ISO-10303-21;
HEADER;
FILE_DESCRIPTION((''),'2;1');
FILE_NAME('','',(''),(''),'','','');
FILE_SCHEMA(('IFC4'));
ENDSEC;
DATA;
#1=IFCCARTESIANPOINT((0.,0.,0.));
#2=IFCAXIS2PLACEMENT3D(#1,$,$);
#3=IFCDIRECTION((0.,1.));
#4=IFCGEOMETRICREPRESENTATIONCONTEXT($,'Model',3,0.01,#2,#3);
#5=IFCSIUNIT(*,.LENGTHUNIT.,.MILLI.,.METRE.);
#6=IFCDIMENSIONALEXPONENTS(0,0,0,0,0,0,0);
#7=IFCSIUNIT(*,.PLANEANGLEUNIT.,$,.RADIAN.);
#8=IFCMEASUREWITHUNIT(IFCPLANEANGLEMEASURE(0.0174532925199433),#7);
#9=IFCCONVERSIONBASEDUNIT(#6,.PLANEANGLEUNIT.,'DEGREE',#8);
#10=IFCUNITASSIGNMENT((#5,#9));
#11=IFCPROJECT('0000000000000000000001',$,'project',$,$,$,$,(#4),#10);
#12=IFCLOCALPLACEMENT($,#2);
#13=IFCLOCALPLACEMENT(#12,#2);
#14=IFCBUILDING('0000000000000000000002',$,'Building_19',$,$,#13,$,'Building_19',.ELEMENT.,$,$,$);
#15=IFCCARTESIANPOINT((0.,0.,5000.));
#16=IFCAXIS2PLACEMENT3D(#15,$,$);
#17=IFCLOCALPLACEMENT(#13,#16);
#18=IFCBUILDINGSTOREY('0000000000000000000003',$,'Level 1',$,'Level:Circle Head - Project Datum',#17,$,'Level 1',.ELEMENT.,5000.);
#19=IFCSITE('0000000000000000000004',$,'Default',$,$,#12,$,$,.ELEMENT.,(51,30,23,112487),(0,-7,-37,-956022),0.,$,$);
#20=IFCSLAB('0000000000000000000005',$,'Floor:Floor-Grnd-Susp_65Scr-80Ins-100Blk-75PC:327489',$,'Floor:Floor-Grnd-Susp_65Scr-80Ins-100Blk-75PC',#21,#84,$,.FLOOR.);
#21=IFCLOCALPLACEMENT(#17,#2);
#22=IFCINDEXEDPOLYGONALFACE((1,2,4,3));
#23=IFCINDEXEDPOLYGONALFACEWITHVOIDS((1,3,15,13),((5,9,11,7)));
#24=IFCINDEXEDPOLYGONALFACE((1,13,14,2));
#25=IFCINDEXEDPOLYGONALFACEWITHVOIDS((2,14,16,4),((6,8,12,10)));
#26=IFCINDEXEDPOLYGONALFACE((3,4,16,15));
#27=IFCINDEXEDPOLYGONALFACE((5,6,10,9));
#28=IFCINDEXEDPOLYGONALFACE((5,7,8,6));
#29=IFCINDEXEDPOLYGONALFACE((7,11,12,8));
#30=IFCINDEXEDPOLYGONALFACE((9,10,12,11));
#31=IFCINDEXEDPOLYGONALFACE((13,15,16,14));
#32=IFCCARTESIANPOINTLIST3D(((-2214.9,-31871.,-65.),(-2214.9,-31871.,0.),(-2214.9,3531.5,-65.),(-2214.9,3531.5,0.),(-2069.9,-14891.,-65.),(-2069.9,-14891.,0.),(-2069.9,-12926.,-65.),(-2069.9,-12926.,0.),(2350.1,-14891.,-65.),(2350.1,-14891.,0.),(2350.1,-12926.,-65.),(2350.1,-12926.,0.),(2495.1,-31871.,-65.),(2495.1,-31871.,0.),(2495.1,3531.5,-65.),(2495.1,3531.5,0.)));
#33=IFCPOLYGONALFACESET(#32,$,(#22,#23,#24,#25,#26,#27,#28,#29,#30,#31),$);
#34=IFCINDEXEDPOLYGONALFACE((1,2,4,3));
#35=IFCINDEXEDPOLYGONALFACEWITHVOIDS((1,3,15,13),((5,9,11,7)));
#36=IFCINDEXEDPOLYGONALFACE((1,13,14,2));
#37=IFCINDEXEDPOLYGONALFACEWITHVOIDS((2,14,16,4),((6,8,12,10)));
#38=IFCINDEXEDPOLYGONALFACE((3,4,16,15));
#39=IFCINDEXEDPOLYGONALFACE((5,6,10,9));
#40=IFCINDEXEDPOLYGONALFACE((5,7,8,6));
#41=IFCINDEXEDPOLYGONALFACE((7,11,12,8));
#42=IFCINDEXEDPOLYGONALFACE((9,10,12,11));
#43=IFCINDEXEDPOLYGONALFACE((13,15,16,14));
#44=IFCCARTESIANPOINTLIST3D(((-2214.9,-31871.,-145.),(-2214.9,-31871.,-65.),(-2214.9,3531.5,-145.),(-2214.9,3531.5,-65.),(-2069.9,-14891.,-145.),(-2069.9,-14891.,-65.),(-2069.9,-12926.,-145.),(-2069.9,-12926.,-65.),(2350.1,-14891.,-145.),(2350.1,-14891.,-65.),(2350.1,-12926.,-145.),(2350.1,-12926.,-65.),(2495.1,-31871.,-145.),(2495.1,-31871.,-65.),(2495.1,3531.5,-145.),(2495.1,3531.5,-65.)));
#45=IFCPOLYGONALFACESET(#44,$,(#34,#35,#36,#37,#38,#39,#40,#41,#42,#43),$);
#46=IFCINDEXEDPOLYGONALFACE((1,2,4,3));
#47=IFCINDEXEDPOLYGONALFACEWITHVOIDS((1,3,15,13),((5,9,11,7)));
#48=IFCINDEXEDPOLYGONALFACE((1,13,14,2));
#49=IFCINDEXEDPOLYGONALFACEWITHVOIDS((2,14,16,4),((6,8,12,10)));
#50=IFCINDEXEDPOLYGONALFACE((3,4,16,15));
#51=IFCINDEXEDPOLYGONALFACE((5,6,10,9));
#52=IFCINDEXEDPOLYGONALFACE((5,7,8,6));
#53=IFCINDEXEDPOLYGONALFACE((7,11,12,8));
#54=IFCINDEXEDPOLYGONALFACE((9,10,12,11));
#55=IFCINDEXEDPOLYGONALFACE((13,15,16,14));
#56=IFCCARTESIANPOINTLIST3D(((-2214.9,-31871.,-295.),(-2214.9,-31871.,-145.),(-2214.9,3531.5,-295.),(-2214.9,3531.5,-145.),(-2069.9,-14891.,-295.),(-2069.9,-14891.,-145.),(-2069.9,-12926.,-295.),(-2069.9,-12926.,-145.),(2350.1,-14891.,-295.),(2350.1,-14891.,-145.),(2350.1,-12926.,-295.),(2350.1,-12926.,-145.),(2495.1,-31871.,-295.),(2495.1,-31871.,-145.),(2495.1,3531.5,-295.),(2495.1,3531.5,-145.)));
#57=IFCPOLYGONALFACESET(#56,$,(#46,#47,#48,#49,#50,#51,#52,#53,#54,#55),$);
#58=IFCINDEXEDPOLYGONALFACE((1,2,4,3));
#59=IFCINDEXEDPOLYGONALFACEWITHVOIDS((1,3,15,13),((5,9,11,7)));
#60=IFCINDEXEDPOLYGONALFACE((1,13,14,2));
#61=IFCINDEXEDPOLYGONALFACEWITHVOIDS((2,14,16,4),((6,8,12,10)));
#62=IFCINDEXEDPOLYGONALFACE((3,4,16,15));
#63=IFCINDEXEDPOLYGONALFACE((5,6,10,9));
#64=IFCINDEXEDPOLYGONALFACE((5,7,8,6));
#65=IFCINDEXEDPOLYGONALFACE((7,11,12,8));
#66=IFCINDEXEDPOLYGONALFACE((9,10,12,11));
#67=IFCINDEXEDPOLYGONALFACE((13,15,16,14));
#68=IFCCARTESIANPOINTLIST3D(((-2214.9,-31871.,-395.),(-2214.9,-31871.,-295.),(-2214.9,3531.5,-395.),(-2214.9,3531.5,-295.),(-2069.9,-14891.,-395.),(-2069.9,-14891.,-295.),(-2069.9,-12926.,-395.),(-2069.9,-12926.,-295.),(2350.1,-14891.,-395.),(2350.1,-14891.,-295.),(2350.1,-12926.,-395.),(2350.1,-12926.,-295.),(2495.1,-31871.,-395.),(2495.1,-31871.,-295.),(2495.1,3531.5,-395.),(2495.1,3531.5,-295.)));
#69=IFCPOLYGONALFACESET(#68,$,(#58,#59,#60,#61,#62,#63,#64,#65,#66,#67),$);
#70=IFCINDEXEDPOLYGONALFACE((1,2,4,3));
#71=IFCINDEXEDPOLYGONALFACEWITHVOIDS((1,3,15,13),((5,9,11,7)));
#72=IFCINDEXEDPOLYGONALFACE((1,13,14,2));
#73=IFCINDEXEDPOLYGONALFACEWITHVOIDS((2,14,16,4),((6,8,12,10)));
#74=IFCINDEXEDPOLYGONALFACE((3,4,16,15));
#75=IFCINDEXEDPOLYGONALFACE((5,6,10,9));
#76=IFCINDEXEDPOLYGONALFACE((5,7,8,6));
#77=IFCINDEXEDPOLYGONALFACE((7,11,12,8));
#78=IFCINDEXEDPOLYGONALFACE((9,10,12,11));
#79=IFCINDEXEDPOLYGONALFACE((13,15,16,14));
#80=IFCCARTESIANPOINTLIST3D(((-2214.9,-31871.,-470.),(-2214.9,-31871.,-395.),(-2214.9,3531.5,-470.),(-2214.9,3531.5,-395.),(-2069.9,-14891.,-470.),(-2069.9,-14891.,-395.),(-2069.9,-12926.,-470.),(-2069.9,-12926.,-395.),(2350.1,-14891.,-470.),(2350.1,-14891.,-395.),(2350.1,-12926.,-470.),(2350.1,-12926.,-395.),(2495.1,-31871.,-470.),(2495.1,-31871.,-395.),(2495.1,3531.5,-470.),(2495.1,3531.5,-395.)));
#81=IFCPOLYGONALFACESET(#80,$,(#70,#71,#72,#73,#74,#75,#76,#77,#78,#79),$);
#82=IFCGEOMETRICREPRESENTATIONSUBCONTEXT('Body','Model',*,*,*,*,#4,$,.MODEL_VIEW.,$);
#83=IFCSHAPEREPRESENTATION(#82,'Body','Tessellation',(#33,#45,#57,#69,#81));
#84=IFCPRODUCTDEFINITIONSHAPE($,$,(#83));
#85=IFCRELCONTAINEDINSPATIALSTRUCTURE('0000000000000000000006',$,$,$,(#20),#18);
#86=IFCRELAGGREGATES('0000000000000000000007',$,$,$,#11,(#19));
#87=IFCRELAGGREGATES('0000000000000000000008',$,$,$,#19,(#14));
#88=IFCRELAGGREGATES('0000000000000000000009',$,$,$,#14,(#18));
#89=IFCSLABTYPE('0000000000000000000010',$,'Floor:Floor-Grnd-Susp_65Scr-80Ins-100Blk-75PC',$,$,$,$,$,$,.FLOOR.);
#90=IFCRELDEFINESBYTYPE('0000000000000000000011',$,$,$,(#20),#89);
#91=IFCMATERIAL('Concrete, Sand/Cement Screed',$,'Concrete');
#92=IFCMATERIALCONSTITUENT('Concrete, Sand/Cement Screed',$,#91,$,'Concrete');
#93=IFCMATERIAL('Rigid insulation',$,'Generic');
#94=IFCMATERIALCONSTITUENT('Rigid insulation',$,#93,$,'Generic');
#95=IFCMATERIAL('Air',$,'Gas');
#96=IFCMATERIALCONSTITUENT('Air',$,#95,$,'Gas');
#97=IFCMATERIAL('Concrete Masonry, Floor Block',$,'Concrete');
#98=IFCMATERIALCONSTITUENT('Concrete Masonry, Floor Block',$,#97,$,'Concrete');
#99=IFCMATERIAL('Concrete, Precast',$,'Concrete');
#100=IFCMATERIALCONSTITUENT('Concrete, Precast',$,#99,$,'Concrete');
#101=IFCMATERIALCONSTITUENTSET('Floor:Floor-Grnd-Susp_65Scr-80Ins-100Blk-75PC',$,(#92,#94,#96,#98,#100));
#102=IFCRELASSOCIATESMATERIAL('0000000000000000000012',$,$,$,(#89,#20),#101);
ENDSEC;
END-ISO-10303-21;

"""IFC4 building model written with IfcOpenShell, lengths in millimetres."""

from ifc_helpers import new_model, entity, si_unit, converted_unit, direction, frame, origin, place, context, subcontext, project, spatial, indexed_curve, outline, extrude, material, constituent, constituent_set, type_object, element, save


model = new_model("IFC4")

# Units and contexts
model_context = context("Model", 3, precision=0.01, world=origin(), true_north=direction((0.0, 1.0)))
body_context = subcontext(model_context, "Body", "Model", "MODEL_VIEW")
ifc_project = project(units=[si_unit("LENGTHUNIT", "METRE", prefix="MILLI"), converted_unit("PLANEANGLEUNIT", "DEGREE", entity("IfcPlaneAngleMeasure", 0.0174532925199433), si_unit("PLANEANGLEUNIT", "RADIAN"), dimensions=[0, 0, 0, 0, 0, 0, 0])], contexts=[model_context])

# Site, building, storey
site_placement = place(None, origin())
site = spatial("IfcSite", under=ifc_project, at=site_placement, Name="Default", CompositionType="ELEMENT", RefLatitude=(51, 30, 23, 112487), RefLongitude=(0, -7, -37, -956022), RefElevation=0.0)
building_placement = place(site_placement, origin())
building = spatial("IfcBuilding", under=site, at=building_placement, Name="Building_19", LongName="Building_19", CompositionType="ELEMENT")
storey_placement = place(building_placement, frame((0.0, 0.0, 5000.0)))
storey = spatial("IfcBuildingStorey", under=building, at=storey_placement, Name="Level 1", ObjectType="Level:Circle Head - Project Datum", LongName="Level 1", CompositionType="ELEMENT", Elevation=5000.0)

# Slab, opening
ifc_material_1 = material(Name="Concrete, Sand/Cement Screed", Category="Concrete")
ifc_constituent_1 = constituent(ifc_material_1, Name="Concrete, Sand/Cement Screed", Category="Concrete")
ifc_material_2 = material(Name="Rigid insulation", Category="Generic")
ifc_constituent_2 = constituent(ifc_material_2, Name="Rigid insulation", Category="Generic")
ifc_material_3 = material(Name="Air", Category="Gas")
ifc_constituent_3 = constituent(ifc_material_3, Name="Air", Category="Gas")
ifc_material_4 = material(Name="Concrete Masonry, Floor Block", Category="Concrete")
ifc_constituent_4 = constituent(ifc_material_4, Name="Concrete Masonry, Floor Block", Category="Concrete")
ifc_material_5 = material(Name="Concrete, Precast", Category="Concrete")
ifc_constituent_5 = constituent(ifc_material_5, Name="Concrete, Precast", Category="Concrete")
ifc_constituent_set_1 = constituent_set(constituents=[ifc_constituent_1, ifc_constituent_2, ifc_constituent_3, ifc_constituent_4, ifc_constituent_5], Name="Floor:Floor-Grnd-Susp_65Scr-80Ins-100Blk-75PC")
slab_type = type_object("IfcSlabType", Name="Floor:Floor-Grnd-Susp_65Scr-80Ins-100Blk-75PC", PredefinedType="FLOOR", material=ifc_constituent_set_1)
slab_1_placement = place(storey_placement, origin())
slab_1 = element("IfcSlab", 1, at=slab_1_placement, inside=storey, type_object=slab_type, material=ifc_constituent_set_1, Name="Floor:Floor-Grnd-Susp_65Scr-80Ins-100Blk-75PC:327489", ObjectType="Floor:Floor-Grnd-Susp_65Scr-80Ins-100Blk-75PC", PredefinedType="FLOOR", context=body_context, shape_type="SweptSolid", body=[
    extrude(outline(indexed_curve([(-2355.0, -17701.2), (2355.0, -17701.2), (2355.0, 17701.2), (-2355.0, 17701.2), (-2355.0, -17701.2)], self_intersect=False), holes=[indexed_curve([(-2210.0, 721.3), (2210.0, 721.2), (2210.0, -1243.8), (-2210.0, -1243.7), (-2210.0, 721.3)], self_intersect=False)]), frame((140.1, -14169.8, -65.0), z_axis=(0.0, 0.0, 1.0), x_axis=(-1.0, 0.0, 0.0)), (0.0, 0.0, 1.0), 65.0),
    extrude(outline(indexed_curve([(-2355.0, -17701.2), (2355.0, -17701.2), (2355.0, 17701.2), (-2355.0, 17701.2), (-2355.0, -17701.2)], self_intersect=False), holes=[indexed_curve([(-2210.0, 721.3), (2210.0, 721.2), (2210.0, -1243.8), (-2210.0, -1243.7), (-2210.0, 721.3)], self_intersect=False)]), frame((140.1, -14169.8, -145.0), z_axis=(0.0, 0.0, 1.0), x_axis=(-1.0, 0.0, 0.0)), (0.0, 0.0, 1.0), 80.0),
    extrude(outline(indexed_curve([(-2355.0, -17701.2), (2355.0, -17701.2), (2355.0, 17701.2), (-2355.0, 17701.2), (-2355.0, -17701.2)], self_intersect=False), holes=[indexed_curve([(-2210.0, 721.3), (2210.0, 721.2), (2210.0, -1243.8), (-2210.0, -1243.7), (-2210.0, 721.3)], self_intersect=False)]), frame((140.1, -14169.8, -295.0), z_axis=(0.0, 0.0, 1.0), x_axis=(-1.0, 0.0, 0.0)), (0.0, 0.0, 1.0), 150.0),
    extrude(outline(indexed_curve([(-2355.0, -17701.2), (2355.0, -17701.2), (2355.0, 17701.2), (-2355.0, 17701.2), (-2355.0, -17701.2)], self_intersect=False), holes=[indexed_curve([(-2210.0, 721.3), (2210.0, 721.2), (2210.0, -1243.8), (-2210.0, -1243.7), (-2210.0, 721.3)], self_intersect=False)]), frame((140.1, -14169.8, -395.0), z_axis=(0.0, 0.0, 1.0), x_axis=(-1.0, 0.0, 0.0)), (0.0, 0.0, 1.0), 100.0),
    extrude(outline(indexed_curve([(-2355.0, -17701.2), (2355.0, -17701.2), (2355.0, 17701.2), (-2355.0, 17701.2), (-2355.0, -17701.2)], self_intersect=False), holes=[indexed_curve([(-2210.0, 721.3), (2210.0, 721.2), (2210.0, -1243.8), (-2210.0, -1243.7), (-2210.0, 721.3)], self_intersect=False)]), frame((140.1, -14169.8, -470.0), z_axis=(0.0, 0.0, 1.0), x_axis=(-1.0, 0.0, 0.0)), (0.0, 0.0, 1.0), 75.0),
])
opening_1_placement = place(slab_1_placement, origin())
element("IfcOpeningElement", 2, at=opening_1_placement, cuts=slab_1, PredefinedType="OPENING", context=body_context, shape_type="SweptSolid", body=[
    extrude(outline(indexed_curve([(-982.5, -2210.0), (982.5, -2210.0), (982.5, 2210.0), (-982.5, 2210.0), (-982.5, -2210.0)], self_intersect=False)), frame((140.1, -13908.5, -470.0), z_axis=(0.0, 0.0, 1.0), x_axis=(0.0, 1.0, 0.0)), (0.0, 0.0, 1.0), 470.0),
])

save(model, "model.ifc")
